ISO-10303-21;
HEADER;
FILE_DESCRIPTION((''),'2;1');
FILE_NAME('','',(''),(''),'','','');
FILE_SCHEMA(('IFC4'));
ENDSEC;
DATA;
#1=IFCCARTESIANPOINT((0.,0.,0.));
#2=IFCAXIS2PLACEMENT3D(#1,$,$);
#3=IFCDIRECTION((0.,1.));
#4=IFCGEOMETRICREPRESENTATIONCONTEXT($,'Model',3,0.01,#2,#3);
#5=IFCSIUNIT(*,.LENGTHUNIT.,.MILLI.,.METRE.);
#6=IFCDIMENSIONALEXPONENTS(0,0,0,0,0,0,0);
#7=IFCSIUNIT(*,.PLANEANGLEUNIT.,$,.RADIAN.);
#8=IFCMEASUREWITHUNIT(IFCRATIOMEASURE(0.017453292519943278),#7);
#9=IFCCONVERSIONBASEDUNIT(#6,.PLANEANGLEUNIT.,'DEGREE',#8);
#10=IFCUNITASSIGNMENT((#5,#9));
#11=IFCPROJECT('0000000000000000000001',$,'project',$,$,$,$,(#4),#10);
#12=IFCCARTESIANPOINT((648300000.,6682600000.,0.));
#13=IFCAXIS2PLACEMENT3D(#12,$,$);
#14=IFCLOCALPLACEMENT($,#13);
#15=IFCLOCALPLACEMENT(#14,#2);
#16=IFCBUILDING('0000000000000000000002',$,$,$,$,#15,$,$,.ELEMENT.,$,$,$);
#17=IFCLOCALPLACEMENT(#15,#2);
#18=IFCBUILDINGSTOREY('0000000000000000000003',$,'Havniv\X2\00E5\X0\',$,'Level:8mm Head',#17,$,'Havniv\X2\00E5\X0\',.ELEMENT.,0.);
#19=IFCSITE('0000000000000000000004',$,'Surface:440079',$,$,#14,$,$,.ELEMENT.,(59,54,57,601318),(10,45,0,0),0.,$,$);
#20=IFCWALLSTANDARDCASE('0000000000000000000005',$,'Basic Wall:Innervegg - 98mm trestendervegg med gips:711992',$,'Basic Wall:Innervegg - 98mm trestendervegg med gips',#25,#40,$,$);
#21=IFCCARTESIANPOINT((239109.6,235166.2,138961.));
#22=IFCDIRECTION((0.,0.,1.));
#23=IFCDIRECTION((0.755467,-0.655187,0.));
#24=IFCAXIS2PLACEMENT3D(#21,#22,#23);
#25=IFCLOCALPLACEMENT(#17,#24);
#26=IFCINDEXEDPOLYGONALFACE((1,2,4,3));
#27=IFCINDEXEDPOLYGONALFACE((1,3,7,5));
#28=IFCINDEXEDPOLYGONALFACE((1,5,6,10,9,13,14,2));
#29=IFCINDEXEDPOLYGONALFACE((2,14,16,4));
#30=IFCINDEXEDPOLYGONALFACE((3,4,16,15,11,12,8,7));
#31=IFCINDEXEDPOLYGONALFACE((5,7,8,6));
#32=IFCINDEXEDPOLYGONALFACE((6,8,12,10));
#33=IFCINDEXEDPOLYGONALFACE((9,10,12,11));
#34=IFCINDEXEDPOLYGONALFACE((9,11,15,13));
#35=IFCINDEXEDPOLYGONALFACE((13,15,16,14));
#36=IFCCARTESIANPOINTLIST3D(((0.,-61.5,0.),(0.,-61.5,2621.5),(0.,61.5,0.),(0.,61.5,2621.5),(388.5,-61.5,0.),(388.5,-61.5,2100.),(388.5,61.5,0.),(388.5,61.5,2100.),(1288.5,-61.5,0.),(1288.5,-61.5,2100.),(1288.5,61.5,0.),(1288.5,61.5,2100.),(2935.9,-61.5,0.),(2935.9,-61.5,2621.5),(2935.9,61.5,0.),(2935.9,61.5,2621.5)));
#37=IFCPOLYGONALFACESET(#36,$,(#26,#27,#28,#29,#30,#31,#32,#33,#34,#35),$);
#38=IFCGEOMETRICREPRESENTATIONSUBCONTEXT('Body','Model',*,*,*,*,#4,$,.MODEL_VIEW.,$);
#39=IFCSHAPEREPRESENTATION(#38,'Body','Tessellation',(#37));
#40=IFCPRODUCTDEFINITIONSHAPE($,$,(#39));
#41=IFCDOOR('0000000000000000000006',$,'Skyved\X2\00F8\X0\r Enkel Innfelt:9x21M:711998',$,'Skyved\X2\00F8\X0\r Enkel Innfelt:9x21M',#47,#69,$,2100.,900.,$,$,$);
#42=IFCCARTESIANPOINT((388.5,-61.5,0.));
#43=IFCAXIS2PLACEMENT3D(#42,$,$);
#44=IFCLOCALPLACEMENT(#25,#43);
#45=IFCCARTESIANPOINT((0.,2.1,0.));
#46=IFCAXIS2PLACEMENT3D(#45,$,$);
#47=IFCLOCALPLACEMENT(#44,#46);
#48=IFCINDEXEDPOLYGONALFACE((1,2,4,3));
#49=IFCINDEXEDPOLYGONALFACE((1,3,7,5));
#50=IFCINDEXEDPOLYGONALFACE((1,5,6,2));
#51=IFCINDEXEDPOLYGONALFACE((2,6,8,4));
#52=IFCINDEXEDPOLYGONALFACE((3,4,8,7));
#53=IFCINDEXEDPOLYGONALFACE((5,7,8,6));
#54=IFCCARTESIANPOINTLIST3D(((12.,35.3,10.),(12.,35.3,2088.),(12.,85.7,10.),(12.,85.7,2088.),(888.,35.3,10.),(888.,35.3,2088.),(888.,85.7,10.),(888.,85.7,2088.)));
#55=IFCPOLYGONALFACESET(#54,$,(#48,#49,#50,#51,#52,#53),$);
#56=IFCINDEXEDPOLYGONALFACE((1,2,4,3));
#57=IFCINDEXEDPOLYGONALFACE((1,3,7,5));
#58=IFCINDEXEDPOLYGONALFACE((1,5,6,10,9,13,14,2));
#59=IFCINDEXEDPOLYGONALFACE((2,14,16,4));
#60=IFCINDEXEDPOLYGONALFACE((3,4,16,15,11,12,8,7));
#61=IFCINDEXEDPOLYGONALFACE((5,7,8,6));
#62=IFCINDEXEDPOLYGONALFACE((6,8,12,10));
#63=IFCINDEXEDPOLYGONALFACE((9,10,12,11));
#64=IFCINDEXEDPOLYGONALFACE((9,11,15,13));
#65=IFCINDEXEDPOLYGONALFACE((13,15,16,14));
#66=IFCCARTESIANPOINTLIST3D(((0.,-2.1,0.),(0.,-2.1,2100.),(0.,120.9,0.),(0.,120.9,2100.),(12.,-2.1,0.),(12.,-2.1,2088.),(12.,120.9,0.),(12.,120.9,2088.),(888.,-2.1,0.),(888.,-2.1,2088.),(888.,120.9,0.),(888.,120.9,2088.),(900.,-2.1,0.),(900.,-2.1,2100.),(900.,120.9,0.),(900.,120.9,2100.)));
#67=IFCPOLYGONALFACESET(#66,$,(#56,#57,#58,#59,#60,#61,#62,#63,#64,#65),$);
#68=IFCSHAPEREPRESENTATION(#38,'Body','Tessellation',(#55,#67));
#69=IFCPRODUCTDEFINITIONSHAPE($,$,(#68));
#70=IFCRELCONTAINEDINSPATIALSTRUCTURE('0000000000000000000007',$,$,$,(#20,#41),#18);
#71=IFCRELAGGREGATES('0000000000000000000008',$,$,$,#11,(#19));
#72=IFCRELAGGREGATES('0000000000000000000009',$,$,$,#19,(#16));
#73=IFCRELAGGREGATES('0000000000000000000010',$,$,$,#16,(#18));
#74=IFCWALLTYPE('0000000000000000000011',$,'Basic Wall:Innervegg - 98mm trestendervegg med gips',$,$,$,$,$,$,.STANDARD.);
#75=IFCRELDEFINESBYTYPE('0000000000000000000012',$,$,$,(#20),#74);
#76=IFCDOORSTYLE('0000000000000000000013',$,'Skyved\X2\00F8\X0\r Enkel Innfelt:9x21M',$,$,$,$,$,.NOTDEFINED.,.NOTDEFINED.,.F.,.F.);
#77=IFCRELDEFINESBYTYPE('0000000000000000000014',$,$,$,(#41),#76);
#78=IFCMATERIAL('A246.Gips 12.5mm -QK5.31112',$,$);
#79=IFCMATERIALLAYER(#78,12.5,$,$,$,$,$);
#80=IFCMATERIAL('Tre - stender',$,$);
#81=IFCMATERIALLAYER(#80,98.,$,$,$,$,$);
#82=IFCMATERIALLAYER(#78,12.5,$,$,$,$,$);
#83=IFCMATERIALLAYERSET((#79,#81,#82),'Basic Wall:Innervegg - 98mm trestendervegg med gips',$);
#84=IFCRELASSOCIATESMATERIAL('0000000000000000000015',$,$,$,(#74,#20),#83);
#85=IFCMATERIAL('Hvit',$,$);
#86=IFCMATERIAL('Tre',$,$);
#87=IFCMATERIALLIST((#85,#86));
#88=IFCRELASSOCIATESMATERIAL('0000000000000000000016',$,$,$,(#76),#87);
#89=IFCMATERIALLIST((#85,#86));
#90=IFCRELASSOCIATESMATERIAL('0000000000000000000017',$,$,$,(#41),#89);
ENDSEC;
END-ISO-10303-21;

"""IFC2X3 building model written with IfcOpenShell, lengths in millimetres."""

from ifc_helpers import new_model, entity, si_unit, converted_unit, direction, frame, frame_2d, origin, place, context, subcontext, project, spatial, polyline, rectangle, outline, extrude, source, transform, mapped, material, material_list, layer, layer_set, layer_usage, type_object, type_shapes, element, fill, save


model = new_model("IFC2X3")

# Units and contexts
model_context = context("Model", 3, precision=0.01, world=origin(), true_north=direction((0.0, 1.0)))
body_context = subcontext(model_context, "Body", "Model", "MODEL_VIEW")
ifc_project = project(units=[si_unit("LENGTHUNIT", "METRE", prefix="MILLI"), converted_unit("PLANEANGLEUNIT", "DEGREE", entity("IfcRatioMeasure", 0.017453292519943278), si_unit("PLANEANGLEUNIT", "RADIAN"), dimensions=[0, 0, 0, 0, 0, 0, 0])], contexts=[model_context])

# Site, building, storey
site_placement = place(None, frame((648300000.0, 6682600000.0, 0.0)))
site = spatial("IfcSite", under=ifc_project, at=site_placement, Name="Surface:440079", CompositionType="ELEMENT", RefLatitude=(59, 54, 57, 601318), RefLongitude=(10, 45, 0, 0), RefElevation=0.0)
building_placement = place(site_placement, origin())
building = spatial("IfcBuilding", under=site, at=building_placement, CompositionType="ELEMENT")
storey_placement = place(building_placement, origin())
storey = spatial("IfcBuildingStorey", under=building, at=storey_placement, Name="Havnivå", ObjectType="Level:8mm Head", LongName="Havnivå", CompositionType="ELEMENT", Elevation=0.0)

# Shared definitions
ifc_material_1 = material(Name="A246.Gips 12.5mm -QK5.31112")
ifc_layer_1 = layer(ifc_material_1, 12.5)
ifc_material_2 = material(Name="Tre - stender")
ifc_layer_2 = layer(ifc_material_2, 98.0)
ifc_layer_3 = layer(ifc_material_1, 12.5)
ifc_layer_set = layer_set([ifc_layer_1, ifc_layer_2, ifc_layer_3], Name="Basic Wall:Innervegg - 98mm trestendervegg med gips")
wall_type = type_object("IfcWallType", Name="Basic Wall:Innervegg - 98mm trestendervegg med gips", PredefinedType="STANDARD", material=ifc_layer_set)
ifc_material_3 = material(Name="Hvit")

# Wall, opening, door
ifc_layer_usage_1 = layer_usage(ifc_layer_set, "AXIS2", "POSITIVE", -61.5)
wall_1_placement = place(storey_placement, frame((239109.6, 235166.2, 138961.0), z_axis=(0.0, 0.0, 1.0), x_axis=(0.755467, -0.655187, 0.0)))
wall_1 = element("IfcWallStandardCase", 1, at=wall_1_placement, inside=storey, type_object=wall_type, material=ifc_layer_usage_1, Name="Basic Wall:Innervegg - 98mm trestendervegg med gips:711992", ObjectType="Basic Wall:Innervegg - 98mm trestendervegg med gips", context=body_context, shape_type="SweptSolid", body=[
    extrude(rectangle(XDim=2935.9, YDim=123.0, at=frame_2d((1468.0, 0.0), x_axis=(1.0, 0.0))), origin(), (0.0, 0.0, 1.0), 2621.5),
])
opening_1_placement = place(wall_1_placement, frame((388.5, -61.5, 0.0)))
opening_1 = element("IfcOpeningElement", 2, at=opening_1_placement, cuts=wall_1, ObjectType="Opening", context=body_context, shape_type="SweptSolid", body=[
    extrude(rectangle(XDim=2100.0, YDim=900.0, at=frame_2d((1050.0, 450.0), x_axis=(1.0, 0.0))), frame((0.0, 0.0, 0.0), z_axis=(0.0, 1.0, 0.0), x_axis=(0.0, 0.0, 1.0)), (0.0, 0.0, 1.0), 123.0),
])
ifc_material_4 = material(Name="Tre")
ifc_material_list_1 = material_list([ifc_material_3, ifc_material_4])
ifc_material_list_2 = material_list([ifc_material_3, ifc_material_4])
door_style_1 = type_object("IfcDoorStyle", Name="Skyvedør Enkel Innfelt:9x21M", ConstructionType="NOTDEFINED", OperationType="NOTDEFINED", ParameterTakesPrecedence=False, Sizeable=False, material=ifc_material_list_2)
shared_shape_1 = source(origin(), body_context, "Body", "SweptSolid", [
    extrude(rectangle(XDim=50.4, YDim=876.0, at=frame_2d((0.0, 0.0), x_axis=(1.0, 0.0))), frame((450.0, 60.5, 10.0), z_axis=(0.0, 0.0, 1.0), x_axis=(0.0, -1.0, 0.0)), (0.0, 0.0, 1.0), 2078.0),
    extrude(outline(polyline([(-450.0, -1047.0), (-438.0, -1047.0), (-438.0, 1041.0), (438.0, 1041.0), (438.0, -1047.0), (450.0, -1047.0), (450.0, 1053.0), (-450.0, 1053.0), (-450.0, -1047.0)])), frame((450.0, 120.9, 1047.0), z_axis=(0.0, -1.0, 0.0), x_axis=(1.0, 0.0, 0.0)), (0.0, 0.0, 1.0), 123.0),
])
type_shapes(door_style_1, [shared_shape_1])
door_1_placement = place(opening_1_placement, frame((0.0, 2.1, 0.0)))
door_1 = element("IfcDoor", 3, at=door_1_placement, inside=storey, type_object=door_style_1, material=ifc_material_list_1, Name="Skyvedør Enkel Innfelt:9x21M:711998", ObjectType="Skyvedør Enkel Innfelt:9x21M", OverallHeight=2100.0, OverallWidth=900.0, context=body_context, shape_type="MappedRepresentation", body=[
    mapped(shared_shape_1, transform((0.0, 0.0, 0.0), scale=1.0)),
])
fill(opening_1, door_1)

save(model, "model.ifc")
